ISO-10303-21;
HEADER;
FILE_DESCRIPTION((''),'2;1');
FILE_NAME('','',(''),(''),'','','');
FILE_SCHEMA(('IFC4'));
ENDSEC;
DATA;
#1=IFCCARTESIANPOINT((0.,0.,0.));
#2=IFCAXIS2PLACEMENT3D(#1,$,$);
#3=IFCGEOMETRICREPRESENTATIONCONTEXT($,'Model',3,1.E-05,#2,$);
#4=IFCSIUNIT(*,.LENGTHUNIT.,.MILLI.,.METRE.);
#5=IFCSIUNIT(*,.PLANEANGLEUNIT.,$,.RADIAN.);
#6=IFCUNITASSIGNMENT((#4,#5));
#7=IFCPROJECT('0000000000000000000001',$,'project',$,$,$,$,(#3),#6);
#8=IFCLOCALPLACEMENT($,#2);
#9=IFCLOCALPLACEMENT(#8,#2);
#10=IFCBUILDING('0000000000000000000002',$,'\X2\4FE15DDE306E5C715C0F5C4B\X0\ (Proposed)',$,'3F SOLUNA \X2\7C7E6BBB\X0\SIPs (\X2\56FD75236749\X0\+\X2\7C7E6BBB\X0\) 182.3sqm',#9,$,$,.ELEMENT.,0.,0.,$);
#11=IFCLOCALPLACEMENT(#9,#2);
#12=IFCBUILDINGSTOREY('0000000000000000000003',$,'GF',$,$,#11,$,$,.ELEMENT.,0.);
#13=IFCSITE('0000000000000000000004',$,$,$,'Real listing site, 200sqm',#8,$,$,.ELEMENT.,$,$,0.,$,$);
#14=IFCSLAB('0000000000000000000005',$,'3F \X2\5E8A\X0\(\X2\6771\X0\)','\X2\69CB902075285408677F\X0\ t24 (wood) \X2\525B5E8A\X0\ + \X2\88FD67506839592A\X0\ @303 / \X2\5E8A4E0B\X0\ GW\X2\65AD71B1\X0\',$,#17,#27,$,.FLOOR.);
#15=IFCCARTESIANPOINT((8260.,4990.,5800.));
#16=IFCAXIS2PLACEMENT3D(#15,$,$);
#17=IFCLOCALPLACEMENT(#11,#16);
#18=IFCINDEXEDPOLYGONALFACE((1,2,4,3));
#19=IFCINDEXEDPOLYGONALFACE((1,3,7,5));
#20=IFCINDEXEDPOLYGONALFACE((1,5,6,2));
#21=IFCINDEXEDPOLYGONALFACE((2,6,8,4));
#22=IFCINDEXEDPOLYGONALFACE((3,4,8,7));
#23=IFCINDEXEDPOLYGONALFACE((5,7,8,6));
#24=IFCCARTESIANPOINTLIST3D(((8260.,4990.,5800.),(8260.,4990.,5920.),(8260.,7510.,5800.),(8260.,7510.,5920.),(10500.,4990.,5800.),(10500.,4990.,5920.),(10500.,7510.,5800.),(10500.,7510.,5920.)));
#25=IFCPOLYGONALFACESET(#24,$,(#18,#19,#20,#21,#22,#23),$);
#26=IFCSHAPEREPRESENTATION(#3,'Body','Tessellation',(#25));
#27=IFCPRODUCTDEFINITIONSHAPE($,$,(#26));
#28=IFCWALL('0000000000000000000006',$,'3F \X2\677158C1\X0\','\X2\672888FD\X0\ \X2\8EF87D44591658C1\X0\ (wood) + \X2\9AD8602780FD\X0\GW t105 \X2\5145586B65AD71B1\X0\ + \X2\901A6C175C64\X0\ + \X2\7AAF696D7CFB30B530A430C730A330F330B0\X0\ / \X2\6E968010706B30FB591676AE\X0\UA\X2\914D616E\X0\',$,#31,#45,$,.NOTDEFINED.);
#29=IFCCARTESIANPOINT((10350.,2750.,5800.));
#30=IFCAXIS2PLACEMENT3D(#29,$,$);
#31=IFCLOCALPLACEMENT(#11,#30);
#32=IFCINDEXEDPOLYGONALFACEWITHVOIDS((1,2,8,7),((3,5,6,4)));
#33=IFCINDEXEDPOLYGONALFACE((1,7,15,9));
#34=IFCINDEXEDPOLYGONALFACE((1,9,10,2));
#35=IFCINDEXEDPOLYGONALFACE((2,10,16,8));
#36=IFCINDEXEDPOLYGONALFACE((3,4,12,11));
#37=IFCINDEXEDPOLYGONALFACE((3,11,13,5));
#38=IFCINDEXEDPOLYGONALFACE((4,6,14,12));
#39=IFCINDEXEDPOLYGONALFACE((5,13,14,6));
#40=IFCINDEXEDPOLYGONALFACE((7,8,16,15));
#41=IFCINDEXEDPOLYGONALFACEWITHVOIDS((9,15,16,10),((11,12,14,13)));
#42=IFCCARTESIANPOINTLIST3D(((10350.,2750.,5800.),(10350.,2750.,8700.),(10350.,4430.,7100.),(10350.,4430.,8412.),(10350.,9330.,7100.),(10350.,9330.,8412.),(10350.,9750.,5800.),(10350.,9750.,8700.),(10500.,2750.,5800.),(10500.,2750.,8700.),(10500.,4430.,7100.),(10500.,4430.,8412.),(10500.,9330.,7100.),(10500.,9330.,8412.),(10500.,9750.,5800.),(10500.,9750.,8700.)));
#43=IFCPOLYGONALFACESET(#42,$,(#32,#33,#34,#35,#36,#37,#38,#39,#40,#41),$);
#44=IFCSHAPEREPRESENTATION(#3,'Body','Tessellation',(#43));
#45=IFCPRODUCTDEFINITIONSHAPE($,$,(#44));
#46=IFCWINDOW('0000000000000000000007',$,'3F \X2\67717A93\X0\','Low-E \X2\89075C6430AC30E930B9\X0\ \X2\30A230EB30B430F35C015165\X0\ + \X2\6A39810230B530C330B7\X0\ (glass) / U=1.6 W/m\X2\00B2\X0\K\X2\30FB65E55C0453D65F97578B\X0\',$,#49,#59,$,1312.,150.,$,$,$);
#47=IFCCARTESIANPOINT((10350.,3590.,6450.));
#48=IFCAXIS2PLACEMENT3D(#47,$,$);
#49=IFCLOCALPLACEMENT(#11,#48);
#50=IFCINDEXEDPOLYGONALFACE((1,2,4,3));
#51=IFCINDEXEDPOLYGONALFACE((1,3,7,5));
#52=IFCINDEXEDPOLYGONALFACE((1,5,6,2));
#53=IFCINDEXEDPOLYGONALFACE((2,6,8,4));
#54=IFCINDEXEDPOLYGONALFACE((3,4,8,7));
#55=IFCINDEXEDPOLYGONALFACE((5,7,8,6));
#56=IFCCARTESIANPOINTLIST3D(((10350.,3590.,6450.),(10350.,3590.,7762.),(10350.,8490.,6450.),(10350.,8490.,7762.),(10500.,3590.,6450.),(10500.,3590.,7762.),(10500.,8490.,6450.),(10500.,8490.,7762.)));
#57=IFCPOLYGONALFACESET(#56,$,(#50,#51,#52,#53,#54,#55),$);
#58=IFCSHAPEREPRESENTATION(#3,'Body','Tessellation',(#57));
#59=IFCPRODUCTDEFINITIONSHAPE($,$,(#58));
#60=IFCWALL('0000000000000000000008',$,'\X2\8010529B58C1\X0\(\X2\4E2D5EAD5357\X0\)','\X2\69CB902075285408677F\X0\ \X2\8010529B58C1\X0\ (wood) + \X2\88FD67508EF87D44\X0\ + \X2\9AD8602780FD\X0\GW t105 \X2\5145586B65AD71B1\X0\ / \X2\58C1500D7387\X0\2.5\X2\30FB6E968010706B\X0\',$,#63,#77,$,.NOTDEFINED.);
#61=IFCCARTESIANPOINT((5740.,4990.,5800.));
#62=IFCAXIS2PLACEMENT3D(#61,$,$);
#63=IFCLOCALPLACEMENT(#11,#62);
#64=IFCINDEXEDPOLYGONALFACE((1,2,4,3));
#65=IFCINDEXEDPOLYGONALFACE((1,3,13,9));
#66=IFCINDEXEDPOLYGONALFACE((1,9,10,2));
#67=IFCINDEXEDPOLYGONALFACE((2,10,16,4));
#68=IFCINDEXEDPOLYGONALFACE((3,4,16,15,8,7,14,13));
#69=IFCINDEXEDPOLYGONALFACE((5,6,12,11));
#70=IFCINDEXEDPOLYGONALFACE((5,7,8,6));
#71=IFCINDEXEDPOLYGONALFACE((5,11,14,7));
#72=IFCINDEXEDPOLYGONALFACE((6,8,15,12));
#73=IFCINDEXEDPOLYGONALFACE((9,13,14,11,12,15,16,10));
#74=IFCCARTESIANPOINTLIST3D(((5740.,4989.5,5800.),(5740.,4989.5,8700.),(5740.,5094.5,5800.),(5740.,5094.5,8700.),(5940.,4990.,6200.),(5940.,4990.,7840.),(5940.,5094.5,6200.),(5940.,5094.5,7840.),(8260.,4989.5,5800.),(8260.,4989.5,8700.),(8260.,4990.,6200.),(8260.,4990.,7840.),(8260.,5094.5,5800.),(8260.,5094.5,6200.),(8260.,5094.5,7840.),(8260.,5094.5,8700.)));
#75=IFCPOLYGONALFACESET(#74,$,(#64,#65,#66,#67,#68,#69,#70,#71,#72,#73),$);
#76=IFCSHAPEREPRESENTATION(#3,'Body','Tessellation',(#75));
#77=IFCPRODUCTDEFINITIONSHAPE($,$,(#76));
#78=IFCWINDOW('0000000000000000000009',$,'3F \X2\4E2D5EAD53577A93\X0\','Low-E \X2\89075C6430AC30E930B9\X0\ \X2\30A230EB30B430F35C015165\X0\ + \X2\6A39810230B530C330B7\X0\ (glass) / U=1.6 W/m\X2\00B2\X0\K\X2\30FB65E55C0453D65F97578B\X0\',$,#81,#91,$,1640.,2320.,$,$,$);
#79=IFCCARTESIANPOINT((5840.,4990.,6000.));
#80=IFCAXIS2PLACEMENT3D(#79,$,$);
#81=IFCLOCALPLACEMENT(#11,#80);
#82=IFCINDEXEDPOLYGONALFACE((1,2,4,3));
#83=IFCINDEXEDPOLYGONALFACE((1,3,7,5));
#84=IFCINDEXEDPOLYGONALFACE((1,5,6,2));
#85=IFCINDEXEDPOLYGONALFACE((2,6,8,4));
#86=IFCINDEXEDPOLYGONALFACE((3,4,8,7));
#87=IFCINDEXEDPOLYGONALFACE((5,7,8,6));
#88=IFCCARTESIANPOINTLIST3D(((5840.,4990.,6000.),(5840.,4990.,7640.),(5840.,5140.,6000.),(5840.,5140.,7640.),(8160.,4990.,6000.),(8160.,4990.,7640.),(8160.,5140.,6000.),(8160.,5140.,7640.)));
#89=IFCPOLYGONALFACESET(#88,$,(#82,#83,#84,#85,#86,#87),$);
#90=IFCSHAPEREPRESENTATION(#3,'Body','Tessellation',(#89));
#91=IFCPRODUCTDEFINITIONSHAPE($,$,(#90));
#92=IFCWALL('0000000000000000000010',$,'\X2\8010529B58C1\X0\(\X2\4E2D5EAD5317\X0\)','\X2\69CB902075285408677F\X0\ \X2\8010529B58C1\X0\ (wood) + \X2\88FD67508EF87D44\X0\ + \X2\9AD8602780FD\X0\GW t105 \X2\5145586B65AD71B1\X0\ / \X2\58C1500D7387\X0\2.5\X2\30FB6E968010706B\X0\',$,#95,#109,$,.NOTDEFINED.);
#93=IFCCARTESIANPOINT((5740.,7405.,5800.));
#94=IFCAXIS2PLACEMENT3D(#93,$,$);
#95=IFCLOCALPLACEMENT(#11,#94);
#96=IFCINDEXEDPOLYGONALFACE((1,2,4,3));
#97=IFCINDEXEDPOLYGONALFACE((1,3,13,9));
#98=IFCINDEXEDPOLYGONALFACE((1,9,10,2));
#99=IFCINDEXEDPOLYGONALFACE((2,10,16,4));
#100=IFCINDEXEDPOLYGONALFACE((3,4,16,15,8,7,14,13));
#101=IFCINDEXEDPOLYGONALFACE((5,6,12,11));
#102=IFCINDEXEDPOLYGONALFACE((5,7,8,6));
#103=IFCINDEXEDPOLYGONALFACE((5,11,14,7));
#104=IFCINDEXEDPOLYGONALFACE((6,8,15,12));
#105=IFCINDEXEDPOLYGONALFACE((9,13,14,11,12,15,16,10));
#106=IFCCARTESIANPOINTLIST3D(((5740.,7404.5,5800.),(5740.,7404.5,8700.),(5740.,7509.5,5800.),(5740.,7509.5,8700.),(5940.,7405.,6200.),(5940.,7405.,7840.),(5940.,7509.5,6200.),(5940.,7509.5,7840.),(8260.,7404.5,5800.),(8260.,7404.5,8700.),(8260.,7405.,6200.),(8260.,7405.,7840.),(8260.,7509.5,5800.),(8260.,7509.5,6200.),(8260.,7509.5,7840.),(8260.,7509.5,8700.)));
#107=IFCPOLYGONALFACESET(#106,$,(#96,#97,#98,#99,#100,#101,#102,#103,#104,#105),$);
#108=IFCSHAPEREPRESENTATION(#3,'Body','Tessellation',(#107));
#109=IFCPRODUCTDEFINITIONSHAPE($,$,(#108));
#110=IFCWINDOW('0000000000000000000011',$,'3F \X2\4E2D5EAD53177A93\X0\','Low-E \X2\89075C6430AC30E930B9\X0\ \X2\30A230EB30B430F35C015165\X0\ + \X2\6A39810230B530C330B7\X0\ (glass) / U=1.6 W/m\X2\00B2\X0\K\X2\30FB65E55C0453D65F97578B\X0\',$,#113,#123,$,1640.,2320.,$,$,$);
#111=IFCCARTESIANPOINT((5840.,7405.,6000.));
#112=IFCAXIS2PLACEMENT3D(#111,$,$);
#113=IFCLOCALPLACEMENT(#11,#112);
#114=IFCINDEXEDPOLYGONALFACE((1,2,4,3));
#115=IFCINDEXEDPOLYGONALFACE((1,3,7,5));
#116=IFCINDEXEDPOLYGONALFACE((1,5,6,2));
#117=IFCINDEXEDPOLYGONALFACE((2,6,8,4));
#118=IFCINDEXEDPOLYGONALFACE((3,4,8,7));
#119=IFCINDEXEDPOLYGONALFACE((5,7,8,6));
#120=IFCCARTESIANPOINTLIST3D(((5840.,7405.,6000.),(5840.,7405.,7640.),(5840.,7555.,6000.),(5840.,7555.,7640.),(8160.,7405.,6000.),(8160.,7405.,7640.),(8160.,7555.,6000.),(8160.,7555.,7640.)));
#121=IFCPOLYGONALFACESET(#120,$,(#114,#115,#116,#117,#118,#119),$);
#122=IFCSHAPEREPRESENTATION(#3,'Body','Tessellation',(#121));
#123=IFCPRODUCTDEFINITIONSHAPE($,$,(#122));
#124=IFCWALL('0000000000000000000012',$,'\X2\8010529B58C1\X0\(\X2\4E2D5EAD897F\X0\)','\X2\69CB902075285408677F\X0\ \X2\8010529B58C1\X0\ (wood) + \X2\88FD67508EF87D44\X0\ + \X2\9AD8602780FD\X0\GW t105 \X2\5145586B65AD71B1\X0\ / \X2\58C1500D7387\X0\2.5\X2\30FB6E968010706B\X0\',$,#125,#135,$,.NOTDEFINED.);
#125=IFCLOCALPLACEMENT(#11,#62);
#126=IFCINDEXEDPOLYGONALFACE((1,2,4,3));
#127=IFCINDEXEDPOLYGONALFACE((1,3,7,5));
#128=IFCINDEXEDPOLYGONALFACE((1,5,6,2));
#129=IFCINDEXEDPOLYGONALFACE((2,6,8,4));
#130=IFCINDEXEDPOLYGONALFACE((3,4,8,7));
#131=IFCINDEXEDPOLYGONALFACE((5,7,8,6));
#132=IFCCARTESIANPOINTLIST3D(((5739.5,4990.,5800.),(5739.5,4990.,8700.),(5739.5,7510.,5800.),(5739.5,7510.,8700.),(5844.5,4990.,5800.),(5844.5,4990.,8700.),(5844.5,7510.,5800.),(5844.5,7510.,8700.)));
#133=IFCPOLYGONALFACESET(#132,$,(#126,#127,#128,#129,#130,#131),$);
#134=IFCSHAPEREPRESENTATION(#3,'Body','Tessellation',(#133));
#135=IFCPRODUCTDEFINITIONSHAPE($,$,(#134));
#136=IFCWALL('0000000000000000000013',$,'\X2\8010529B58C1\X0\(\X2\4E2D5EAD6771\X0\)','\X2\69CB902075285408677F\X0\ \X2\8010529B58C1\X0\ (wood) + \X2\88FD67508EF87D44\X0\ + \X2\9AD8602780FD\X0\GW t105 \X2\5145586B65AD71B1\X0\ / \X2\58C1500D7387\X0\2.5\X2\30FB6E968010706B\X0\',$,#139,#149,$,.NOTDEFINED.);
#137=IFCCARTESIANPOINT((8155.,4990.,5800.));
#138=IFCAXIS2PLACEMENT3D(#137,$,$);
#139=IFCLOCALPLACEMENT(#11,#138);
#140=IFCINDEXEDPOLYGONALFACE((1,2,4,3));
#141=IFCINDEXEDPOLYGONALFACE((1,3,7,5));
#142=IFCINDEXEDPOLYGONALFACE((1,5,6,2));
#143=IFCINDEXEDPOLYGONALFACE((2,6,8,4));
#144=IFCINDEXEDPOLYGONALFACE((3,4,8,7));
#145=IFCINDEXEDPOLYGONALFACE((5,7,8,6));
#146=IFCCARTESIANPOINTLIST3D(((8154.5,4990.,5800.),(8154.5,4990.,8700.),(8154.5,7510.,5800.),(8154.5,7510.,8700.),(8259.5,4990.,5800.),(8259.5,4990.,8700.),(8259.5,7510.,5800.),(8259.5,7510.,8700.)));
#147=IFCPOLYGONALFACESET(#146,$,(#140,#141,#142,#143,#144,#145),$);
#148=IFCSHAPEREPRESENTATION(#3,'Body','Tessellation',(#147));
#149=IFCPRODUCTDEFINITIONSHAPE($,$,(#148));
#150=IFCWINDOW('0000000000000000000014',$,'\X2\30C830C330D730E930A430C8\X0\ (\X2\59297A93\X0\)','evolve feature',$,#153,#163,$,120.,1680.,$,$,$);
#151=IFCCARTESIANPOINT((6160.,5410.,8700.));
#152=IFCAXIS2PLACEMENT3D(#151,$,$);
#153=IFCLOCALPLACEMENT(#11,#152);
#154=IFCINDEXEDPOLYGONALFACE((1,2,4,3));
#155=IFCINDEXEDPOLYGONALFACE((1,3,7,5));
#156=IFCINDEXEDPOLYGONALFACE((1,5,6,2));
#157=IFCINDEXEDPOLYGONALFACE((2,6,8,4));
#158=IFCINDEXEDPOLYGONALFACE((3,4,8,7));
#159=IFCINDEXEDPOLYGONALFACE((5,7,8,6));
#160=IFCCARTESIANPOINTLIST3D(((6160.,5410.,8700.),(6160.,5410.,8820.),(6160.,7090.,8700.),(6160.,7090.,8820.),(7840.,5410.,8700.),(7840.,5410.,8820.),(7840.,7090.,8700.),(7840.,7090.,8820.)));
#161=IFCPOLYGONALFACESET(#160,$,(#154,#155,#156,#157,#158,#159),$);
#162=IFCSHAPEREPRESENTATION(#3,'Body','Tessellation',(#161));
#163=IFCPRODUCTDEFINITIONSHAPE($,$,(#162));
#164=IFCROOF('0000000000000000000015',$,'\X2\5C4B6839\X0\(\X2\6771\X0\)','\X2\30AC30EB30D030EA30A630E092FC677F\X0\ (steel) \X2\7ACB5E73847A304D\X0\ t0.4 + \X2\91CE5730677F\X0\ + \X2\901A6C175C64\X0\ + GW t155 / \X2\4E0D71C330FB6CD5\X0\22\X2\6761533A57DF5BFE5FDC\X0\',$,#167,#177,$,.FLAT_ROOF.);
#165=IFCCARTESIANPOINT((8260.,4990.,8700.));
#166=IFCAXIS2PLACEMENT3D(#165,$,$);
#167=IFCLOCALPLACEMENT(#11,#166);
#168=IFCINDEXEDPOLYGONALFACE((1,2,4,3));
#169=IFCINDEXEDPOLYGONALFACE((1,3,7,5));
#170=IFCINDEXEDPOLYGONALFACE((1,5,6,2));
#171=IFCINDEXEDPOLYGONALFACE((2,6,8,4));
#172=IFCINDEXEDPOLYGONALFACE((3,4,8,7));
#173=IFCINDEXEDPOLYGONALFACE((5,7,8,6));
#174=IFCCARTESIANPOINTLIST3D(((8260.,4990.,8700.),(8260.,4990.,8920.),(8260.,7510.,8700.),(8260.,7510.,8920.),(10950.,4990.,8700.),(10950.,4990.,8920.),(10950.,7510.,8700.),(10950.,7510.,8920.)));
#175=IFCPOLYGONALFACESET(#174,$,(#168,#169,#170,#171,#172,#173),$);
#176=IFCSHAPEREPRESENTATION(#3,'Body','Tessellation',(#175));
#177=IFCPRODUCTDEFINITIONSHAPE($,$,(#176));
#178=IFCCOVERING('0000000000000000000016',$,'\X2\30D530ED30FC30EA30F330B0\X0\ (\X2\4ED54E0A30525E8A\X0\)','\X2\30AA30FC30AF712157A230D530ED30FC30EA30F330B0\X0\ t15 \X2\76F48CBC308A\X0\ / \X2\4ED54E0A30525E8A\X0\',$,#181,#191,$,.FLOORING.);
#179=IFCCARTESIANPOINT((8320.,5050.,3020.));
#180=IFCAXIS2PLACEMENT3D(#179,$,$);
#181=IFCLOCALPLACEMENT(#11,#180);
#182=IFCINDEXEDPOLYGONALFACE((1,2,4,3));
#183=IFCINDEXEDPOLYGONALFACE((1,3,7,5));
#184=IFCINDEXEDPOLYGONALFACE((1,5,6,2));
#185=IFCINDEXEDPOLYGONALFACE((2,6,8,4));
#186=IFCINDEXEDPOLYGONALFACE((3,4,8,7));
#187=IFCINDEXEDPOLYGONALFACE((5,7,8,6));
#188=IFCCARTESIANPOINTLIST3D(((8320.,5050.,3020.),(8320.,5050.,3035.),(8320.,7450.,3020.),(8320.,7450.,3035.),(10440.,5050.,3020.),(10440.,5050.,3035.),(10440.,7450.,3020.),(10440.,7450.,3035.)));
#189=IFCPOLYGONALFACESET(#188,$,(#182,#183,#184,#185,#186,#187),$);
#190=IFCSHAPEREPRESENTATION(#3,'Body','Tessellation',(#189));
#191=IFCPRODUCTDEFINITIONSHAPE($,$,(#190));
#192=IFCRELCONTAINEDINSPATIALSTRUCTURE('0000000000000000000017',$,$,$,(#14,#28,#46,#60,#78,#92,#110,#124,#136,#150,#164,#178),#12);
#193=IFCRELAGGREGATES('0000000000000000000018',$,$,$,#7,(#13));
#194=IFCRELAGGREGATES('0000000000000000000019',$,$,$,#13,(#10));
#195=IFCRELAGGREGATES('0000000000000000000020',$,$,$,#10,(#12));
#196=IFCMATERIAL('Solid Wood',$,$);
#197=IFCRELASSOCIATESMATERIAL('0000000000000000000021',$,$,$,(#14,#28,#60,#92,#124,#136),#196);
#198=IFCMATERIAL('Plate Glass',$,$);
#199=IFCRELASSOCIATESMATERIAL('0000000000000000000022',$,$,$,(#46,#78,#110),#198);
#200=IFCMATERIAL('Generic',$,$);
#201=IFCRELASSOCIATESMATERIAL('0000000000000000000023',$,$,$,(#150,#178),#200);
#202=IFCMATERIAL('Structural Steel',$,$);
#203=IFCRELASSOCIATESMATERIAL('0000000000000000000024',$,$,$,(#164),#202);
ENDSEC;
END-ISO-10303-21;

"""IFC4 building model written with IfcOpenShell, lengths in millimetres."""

from ifc_helpers import new_model, si_unit, frame, frame_2d, origin, place, context, project, spatial, rectangle, extrude, material, element, fill, save


model = new_model("IFC4")

# Units and contexts
model_context = context("Model", 3, precision=1e-05, world=origin())
ifc_project = project(units=[si_unit("LENGTHUNIT", "METRE", prefix="MILLI"), si_unit("PLANEANGLEUNIT", "RADIAN")], contexts=[model_context])

# Site, building, storey
site_placement = place(None, origin())
site = spatial("IfcSite", under=ifc_project, at=site_placement, ObjectType="Real listing site, 200sqm", CompositionType="ELEMENT", RefElevation=0.0)
building_placement = place(site_placement, origin())
building = spatial("IfcBuilding", under=site, at=building_placement, Name="信州の山小屋 (Proposed)", ObjectType="3F SOLUNA 籾殻SIPs (国産杉+籾殻) 182.3sqm", CompositionType="ELEMENT", ElevationOfRefHeight=0.0, ElevationOfTerrain=0.0)
storey_placement = place(building_placement, origin())
storey = spatial("IfcBuildingStorey", under=building, at=storey_placement, Name="GF", CompositionType="ELEMENT", Elevation=0.0)

# Slab
ifc_material_1 = material(Name="Solid Wood")
slab_placement = place(storey_placement, frame((8260.0, 4990.0, 5800.0)))
element("IfcSlab", 1, at=slab_placement, inside=storey, material=ifc_material_1, Name="3F 床(東)", Description="構造用合板 t24 (wood) 剛床 + 製材根太 @303 / 床下 GW断熱", PredefinedType="FLOOR", context=model_context, shape_type="SweptSolid", body=[
    extrude(rectangle(XDim=2240.0, YDim=2520.0, at=frame_2d((1120.0, 1260.0))), frame((8260.0, 4990.0, 5800.0)), (0.0, 0.0, 1.0), 120.0),
])

# Walls, openings, windows
wall_1_placement = place(storey_placement, frame((10350.0, 2750.0, 5800.0)))
wall_1 = element("IfcWall", 2, at=wall_1_placement, inside=storey, material=ifc_material_1, Name="3F 東壁", Description="木製 軸組外壁 (wood) + 高性能GW t105 充填断熱 + 通気層 + 窯業系サイディング / 準耐火・外皮UA配慮", PredefinedType="NOTDEFINED", context=model_context, shape_type="SweptSolid", body=[
    extrude(rectangle(XDim=150.0, YDim=7000.0, at=frame_2d((75.0, 3500.0))), frame((10350.0, 2750.0, 5800.0)), (0.0, 0.0, 1.0), 2900.0),
])
opening_1_placement = place(storey_placement, frame((10350.0, 3590.0, 6450.0)))
opening_1 = element("IfcOpeningElement", 3, at=opening_1_placement, cuts=wall_1, PredefinedType="NOTDEFINED", context=model_context, shape_type="SweptSolid", body=[
    extrude(rectangle(XDim=150.0, YDim=4900.0, at=frame_2d((75.0, 2450.0))), frame((10350.0, 3590.0, 6450.0)), (0.0, 0.0, 1.0), 1312.0),
])
ifc_material_2 = material(Name="Plate Glass")
window_1_placement = place(storey_placement, frame((10350.0, 3590.0, 6450.0)))
window_1 = element("IfcWindow", 4, at=window_1_placement, inside=storey, material=ifc_material_2, Name="3F 東窓", Description="Low-E 複層ガラス アルゴン封入 + 樹脂サッシ (glass) / U=1.6 W/m²K・日射取得型", OverallHeight=1312.0, OverallWidth=150.0, context=model_context, shape_type="SweptSolid", body=[
    extrude(rectangle(XDim=150.0, YDim=4900.0, at=frame_2d((75.0, 2450.0))), frame((10350.0, 3590.0, 6450.0)), (0.0, 0.0, 1.0), 1312.0),
])
fill(opening_1, window_1)
wall_2_placement = place(storey_placement, frame((5740.0, 4990.0, 5800.0)))
wall_2 = element("IfcWall", 5, at=wall_2_placement, inside=storey, material=ifc_material_1, Name="耐力壁(中庭南)", Description="構造用合板 耐力壁 (wood) + 製材軸組 + 高性能GW t105 充填断熱 / 壁倍率2.5・準耐火", PredefinedType="NOTDEFINED", context=model_context, shape_type="SweptSolid", body=[
    extrude(rectangle(XDim=2520.0, YDim=105.0, at=frame_2d((1260.0, 52.0))), frame((5740.0, 4990.0, 5800.0)), (0.0, 0.0, 1.0), 2900.0),
])
opening_2_placement = place(storey_placement, frame((5840.0, 4990.0, 6000.0)))
opening_2 = element("IfcOpeningElement", 6, at=opening_2_placement, cuts=wall_2, PredefinedType="NOTDEFINED", context=model_context, shape_type="SweptSolid", body=[
    extrude(rectangle(XDim=2320.0, YDim=150.0, at=frame_2d((1160.0, 75.0))), frame((5840.0, 4990.0, 6000.0)), (0.0, 0.0, 1.0), 1640.0),
])
window_2_placement = place(storey_placement, frame((5840.0, 4990.0, 6000.0)))
window_2 = element("IfcWindow", 7, at=window_2_placement, inside=storey, material=ifc_material_2, Name="3F 中庭南窓", Description="Low-E 複層ガラス アルゴン封入 + 樹脂サッシ (glass) / U=1.6 W/m²K・日射取得型", OverallHeight=1640.0, OverallWidth=2320.0, context=model_context, shape_type="SweptSolid", body=[
    extrude(rectangle(XDim=2320.0, YDim=150.0, at=frame_2d((1160.0, 75.0))), frame((5840.0, 4990.0, 6000.0)), (0.0, 0.0, 1.0), 1640.0),
])
fill(opening_2, window_2)
wall_3_placement = place(storey_placement, frame((5740.0, 7405.0, 5800.0)))
wall_3 = element("IfcWall", 8, at=wall_3_placement, inside=storey, material=ifc_material_1, Name="耐力壁(中庭北)", Description="構造用合板 耐力壁 (wood) + 製材軸組 + 高性能GW t105 充填断熱 / 壁倍率2.5・準耐火", PredefinedType="NOTDEFINED", context=model_context, shape_type="SweptSolid", body=[
    extrude(rectangle(XDim=2520.0, YDim=105.0, at=frame_2d((1260.0, 52.0))), frame((5740.0, 7405.0, 5800.0)), (0.0, 0.0, 1.0), 2900.0),
])
opening_3_placement = place(storey_placement, frame((5840.0, 7405.0, 6000.0)))
opening_3 = element("IfcOpeningElement", 9, at=opening_3_placement, cuts=wall_3, PredefinedType="NOTDEFINED", context=model_context, shape_type="SweptSolid", body=[
    extrude(rectangle(XDim=2320.0, YDim=150.0, at=frame_2d((1160.0, 75.0))), frame((5840.0, 7405.0, 6000.0)), (0.0, 0.0, 1.0), 1640.0),
])
window_3_placement = place(storey_placement, frame((5840.0, 7405.0, 6000.0)))
window_3 = element("IfcWindow", 10, at=window_3_placement, inside=storey, material=ifc_material_2, Name="3F 中庭北窓", Description="Low-E 複層ガラス アルゴン封入 + 樹脂サッシ (glass) / U=1.6 W/m²K・日射取得型", OverallHeight=1640.0, OverallWidth=2320.0, context=model_context, shape_type="SweptSolid", body=[
    extrude(rectangle(XDim=2320.0, YDim=150.0, at=frame_2d((1160.0, 75.0))), frame((5840.0, 7405.0, 6000.0)), (0.0, 0.0, 1.0), 1640.0),
])
fill(opening_3, window_3)

# Walls
wall_4_placement = place(storey_placement, frame((5740.0, 4990.0, 5800.0)))
element("IfcWall", 11, at=wall_4_placement, inside=storey, material=ifc_material_1, Name="耐力壁(中庭西)", Description="構造用合板 耐力壁 (wood) + 製材軸組 + 高性能GW t105 充填断熱 / 壁倍率2.5・準耐火", PredefinedType="NOTDEFINED", context=model_context, shape_type="SweptSolid", body=[
    extrude(rectangle(XDim=105.0, YDim=2520.0, at=frame_2d((52.0, 1260.0))), frame((5740.0, 4990.0, 5800.0)), (0.0, 0.0, 1.0), 2900.0),
])
wall_5_placement = place(storey_placement, frame((8155.0, 4990.0, 5800.0)))
element("IfcWall", 12, at=wall_5_placement, inside=storey, material=ifc_material_1, Name="耐力壁(中庭東)", Description="構造用合板 耐力壁 (wood) + 製材軸組 + 高性能GW t105 充填断熱 / 壁倍率2.5・準耐火", PredefinedType="NOTDEFINED", context=model_context, shape_type="SweptSolid", body=[
    extrude(rectangle(XDim=105.0, YDim=2520.0, at=frame_2d((52.0, 1260.0))), frame((8155.0, 4990.0, 5800.0)), (0.0, 0.0, 1.0), 2900.0),
])

# Window
ifc_material_3 = material(Name="Generic")
window_4_placement = place(storey_placement, frame((6160.0, 5410.0, 8700.0)))
element("IfcWindow", 13, at=window_4_placement, inside=storey, material=ifc_material_3, Name="トップライト (天窓)", Description="evolve feature", OverallHeight=120.0, OverallWidth=1680.0, context=model_context, shape_type="SweptSolid", body=[
    extrude(rectangle(XDim=1680.0, YDim=1680.0, at=frame_2d((840.0, 840.0))), frame((6160.0, 5410.0, 8700.0)), (0.0, 0.0, 1.0), 120.0),
])

# Roof
ifc_material_4 = material(Name="Structural Steel")
for number, where, name in (
    (14, (8260.0, 4990.0, 8700.0), "屋根(東)"),
):
    element("IfcRoof", number, at=place(storey_placement, frame(where)), inside=storey, material=ifc_material_4, Name=name, Description="ガルバリウム鋼板 (steel) 立平葺き t0.4 + 野地板 + 通気層 + GW t155 / 不燃・法22条区域対応", PredefinedType="FLAT_ROOF", context=model_context, shape_type="SweptSolid", body=[
        extrude(rectangle(XDim=2690.0, YDim=2520.0, at=frame_2d((1345.0, 1260.0))), frame((8260.0, 4990.0, 8700.0)), (0.0, 0.0, 1.0), 220.0),
    ])

# Covering
covering_1_placement = place(storey_placement, frame((8320.0, 5050.0, 3020.0)))
element("IfcCovering", 15, at=covering_1_placement, inside=storey, material=ifc_material_3, Name="フローリング (仕上げ床)", Description="オーク無垢フローリング t15 直貼り / 仕上げ床", PredefinedType="FLOORING", context=model_context, shape_type="SweptSolid", body=[
    extrude(rectangle(XDim=2120.0, YDim=2400.0, at=frame_2d((1060.0, 1200.0))), frame((8320.0, 5050.0, 3020.0)), (0.0, 0.0, 1.0), 15.0),
])

save(model, "model.ifc")
